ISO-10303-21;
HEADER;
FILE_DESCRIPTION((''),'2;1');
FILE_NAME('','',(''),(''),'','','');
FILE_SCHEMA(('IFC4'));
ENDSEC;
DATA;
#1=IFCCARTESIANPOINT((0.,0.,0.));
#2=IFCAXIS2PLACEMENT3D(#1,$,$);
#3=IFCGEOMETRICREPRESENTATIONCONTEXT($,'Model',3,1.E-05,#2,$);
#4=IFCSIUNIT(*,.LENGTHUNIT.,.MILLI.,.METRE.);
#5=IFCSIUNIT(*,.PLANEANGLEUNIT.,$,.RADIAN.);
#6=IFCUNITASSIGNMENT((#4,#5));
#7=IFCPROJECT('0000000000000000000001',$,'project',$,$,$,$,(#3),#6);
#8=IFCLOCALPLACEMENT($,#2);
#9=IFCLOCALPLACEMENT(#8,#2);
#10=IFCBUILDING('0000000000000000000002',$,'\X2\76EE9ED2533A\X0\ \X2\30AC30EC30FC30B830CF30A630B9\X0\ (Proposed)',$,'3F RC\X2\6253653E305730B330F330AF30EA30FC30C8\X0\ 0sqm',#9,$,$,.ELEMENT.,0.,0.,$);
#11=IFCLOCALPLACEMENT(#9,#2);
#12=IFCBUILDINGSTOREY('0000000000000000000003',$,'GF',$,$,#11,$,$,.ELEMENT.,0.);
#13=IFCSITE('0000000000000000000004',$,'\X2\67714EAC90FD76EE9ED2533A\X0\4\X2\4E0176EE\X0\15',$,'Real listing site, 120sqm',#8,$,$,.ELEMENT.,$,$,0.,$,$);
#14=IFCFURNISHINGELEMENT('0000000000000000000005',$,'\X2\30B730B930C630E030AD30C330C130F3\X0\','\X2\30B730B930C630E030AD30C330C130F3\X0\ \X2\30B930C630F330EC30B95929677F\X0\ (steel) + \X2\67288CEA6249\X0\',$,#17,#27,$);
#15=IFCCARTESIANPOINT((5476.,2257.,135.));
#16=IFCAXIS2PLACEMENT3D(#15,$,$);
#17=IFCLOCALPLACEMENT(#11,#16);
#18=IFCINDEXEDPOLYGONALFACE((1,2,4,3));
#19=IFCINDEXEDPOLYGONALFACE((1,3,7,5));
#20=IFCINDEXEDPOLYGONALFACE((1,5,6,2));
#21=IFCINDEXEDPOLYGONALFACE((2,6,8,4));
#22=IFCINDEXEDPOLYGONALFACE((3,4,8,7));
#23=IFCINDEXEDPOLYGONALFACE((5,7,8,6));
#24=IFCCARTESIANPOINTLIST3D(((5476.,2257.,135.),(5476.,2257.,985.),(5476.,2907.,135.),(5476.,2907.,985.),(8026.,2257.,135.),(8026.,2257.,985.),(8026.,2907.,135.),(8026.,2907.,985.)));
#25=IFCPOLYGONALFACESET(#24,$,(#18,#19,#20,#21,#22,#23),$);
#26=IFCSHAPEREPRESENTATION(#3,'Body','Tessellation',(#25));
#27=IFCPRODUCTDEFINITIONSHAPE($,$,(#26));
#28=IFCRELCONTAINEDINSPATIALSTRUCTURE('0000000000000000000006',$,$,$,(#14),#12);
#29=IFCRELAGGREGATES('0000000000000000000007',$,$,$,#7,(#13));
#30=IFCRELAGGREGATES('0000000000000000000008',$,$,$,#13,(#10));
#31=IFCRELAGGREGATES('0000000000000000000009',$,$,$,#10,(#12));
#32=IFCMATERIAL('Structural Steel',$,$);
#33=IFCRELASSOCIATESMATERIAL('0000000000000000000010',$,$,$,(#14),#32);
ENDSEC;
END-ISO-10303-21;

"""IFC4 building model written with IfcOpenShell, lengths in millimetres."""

from ifc_helpers import new_model, si_unit, frame, frame_2d, origin, place, context, project, spatial, rectangle, extrude, material, element, save


model = new_model("IFC4")

# Units and contexts
model_context = context("Model", 3, precision=1e-05, world=origin())
ifc_project = project(units=[si_unit("LENGTHUNIT", "METRE", prefix="MILLI"), si_unit("PLANEANGLEUNIT", "RADIAN")], contexts=[model_context])

# Site, building, storey
site_placement = place(None, origin())
site = spatial("IfcSite", under=ifc_project, at=site_placement, Name="東京都目黒区4丁目15", ObjectType="Real listing site, 120sqm", CompositionType="ELEMENT", RefElevation=0.0)
building_placement = place(site_placement, origin())
building = spatial("IfcBuilding", under=site, at=building_placement, Name="目黒区 ガレージハウス (Proposed)", ObjectType="3F RC打放しコンクリート 0sqm", CompositionType="ELEMENT", ElevationOfRefHeight=0.0, ElevationOfTerrain=0.0)
storey_placement = place(building_placement, origin())
storey = spatial("IfcBuildingStorey", under=building, at=storey_placement, Name="GF", CompositionType="ELEMENT", Elevation=0.0)

# Furnishing element
ifc_material_1 = material(Name="Structural Steel")
furnishing_1_placement = place(storey_placement, frame((5476.0, 2257.0, 135.0)))
element("IfcFurnishingElement", 1, at=furnishing_1_placement, inside=storey, material=ifc_material_1, Name="システムキッチン", Description="システムキッチン ステンレス天板 (steel) + 木質扉", context=model_context, shape_type="SweptSolid", body=[
    extrude(rectangle(XDim=2550.0, YDim=650.0, at=frame_2d((1275.0, 325.0))), frame((5476.0, 2257.0, 135.0)), (0.0, 0.0, 1.0), 850.0),
])

save(model, "model.ifc")
